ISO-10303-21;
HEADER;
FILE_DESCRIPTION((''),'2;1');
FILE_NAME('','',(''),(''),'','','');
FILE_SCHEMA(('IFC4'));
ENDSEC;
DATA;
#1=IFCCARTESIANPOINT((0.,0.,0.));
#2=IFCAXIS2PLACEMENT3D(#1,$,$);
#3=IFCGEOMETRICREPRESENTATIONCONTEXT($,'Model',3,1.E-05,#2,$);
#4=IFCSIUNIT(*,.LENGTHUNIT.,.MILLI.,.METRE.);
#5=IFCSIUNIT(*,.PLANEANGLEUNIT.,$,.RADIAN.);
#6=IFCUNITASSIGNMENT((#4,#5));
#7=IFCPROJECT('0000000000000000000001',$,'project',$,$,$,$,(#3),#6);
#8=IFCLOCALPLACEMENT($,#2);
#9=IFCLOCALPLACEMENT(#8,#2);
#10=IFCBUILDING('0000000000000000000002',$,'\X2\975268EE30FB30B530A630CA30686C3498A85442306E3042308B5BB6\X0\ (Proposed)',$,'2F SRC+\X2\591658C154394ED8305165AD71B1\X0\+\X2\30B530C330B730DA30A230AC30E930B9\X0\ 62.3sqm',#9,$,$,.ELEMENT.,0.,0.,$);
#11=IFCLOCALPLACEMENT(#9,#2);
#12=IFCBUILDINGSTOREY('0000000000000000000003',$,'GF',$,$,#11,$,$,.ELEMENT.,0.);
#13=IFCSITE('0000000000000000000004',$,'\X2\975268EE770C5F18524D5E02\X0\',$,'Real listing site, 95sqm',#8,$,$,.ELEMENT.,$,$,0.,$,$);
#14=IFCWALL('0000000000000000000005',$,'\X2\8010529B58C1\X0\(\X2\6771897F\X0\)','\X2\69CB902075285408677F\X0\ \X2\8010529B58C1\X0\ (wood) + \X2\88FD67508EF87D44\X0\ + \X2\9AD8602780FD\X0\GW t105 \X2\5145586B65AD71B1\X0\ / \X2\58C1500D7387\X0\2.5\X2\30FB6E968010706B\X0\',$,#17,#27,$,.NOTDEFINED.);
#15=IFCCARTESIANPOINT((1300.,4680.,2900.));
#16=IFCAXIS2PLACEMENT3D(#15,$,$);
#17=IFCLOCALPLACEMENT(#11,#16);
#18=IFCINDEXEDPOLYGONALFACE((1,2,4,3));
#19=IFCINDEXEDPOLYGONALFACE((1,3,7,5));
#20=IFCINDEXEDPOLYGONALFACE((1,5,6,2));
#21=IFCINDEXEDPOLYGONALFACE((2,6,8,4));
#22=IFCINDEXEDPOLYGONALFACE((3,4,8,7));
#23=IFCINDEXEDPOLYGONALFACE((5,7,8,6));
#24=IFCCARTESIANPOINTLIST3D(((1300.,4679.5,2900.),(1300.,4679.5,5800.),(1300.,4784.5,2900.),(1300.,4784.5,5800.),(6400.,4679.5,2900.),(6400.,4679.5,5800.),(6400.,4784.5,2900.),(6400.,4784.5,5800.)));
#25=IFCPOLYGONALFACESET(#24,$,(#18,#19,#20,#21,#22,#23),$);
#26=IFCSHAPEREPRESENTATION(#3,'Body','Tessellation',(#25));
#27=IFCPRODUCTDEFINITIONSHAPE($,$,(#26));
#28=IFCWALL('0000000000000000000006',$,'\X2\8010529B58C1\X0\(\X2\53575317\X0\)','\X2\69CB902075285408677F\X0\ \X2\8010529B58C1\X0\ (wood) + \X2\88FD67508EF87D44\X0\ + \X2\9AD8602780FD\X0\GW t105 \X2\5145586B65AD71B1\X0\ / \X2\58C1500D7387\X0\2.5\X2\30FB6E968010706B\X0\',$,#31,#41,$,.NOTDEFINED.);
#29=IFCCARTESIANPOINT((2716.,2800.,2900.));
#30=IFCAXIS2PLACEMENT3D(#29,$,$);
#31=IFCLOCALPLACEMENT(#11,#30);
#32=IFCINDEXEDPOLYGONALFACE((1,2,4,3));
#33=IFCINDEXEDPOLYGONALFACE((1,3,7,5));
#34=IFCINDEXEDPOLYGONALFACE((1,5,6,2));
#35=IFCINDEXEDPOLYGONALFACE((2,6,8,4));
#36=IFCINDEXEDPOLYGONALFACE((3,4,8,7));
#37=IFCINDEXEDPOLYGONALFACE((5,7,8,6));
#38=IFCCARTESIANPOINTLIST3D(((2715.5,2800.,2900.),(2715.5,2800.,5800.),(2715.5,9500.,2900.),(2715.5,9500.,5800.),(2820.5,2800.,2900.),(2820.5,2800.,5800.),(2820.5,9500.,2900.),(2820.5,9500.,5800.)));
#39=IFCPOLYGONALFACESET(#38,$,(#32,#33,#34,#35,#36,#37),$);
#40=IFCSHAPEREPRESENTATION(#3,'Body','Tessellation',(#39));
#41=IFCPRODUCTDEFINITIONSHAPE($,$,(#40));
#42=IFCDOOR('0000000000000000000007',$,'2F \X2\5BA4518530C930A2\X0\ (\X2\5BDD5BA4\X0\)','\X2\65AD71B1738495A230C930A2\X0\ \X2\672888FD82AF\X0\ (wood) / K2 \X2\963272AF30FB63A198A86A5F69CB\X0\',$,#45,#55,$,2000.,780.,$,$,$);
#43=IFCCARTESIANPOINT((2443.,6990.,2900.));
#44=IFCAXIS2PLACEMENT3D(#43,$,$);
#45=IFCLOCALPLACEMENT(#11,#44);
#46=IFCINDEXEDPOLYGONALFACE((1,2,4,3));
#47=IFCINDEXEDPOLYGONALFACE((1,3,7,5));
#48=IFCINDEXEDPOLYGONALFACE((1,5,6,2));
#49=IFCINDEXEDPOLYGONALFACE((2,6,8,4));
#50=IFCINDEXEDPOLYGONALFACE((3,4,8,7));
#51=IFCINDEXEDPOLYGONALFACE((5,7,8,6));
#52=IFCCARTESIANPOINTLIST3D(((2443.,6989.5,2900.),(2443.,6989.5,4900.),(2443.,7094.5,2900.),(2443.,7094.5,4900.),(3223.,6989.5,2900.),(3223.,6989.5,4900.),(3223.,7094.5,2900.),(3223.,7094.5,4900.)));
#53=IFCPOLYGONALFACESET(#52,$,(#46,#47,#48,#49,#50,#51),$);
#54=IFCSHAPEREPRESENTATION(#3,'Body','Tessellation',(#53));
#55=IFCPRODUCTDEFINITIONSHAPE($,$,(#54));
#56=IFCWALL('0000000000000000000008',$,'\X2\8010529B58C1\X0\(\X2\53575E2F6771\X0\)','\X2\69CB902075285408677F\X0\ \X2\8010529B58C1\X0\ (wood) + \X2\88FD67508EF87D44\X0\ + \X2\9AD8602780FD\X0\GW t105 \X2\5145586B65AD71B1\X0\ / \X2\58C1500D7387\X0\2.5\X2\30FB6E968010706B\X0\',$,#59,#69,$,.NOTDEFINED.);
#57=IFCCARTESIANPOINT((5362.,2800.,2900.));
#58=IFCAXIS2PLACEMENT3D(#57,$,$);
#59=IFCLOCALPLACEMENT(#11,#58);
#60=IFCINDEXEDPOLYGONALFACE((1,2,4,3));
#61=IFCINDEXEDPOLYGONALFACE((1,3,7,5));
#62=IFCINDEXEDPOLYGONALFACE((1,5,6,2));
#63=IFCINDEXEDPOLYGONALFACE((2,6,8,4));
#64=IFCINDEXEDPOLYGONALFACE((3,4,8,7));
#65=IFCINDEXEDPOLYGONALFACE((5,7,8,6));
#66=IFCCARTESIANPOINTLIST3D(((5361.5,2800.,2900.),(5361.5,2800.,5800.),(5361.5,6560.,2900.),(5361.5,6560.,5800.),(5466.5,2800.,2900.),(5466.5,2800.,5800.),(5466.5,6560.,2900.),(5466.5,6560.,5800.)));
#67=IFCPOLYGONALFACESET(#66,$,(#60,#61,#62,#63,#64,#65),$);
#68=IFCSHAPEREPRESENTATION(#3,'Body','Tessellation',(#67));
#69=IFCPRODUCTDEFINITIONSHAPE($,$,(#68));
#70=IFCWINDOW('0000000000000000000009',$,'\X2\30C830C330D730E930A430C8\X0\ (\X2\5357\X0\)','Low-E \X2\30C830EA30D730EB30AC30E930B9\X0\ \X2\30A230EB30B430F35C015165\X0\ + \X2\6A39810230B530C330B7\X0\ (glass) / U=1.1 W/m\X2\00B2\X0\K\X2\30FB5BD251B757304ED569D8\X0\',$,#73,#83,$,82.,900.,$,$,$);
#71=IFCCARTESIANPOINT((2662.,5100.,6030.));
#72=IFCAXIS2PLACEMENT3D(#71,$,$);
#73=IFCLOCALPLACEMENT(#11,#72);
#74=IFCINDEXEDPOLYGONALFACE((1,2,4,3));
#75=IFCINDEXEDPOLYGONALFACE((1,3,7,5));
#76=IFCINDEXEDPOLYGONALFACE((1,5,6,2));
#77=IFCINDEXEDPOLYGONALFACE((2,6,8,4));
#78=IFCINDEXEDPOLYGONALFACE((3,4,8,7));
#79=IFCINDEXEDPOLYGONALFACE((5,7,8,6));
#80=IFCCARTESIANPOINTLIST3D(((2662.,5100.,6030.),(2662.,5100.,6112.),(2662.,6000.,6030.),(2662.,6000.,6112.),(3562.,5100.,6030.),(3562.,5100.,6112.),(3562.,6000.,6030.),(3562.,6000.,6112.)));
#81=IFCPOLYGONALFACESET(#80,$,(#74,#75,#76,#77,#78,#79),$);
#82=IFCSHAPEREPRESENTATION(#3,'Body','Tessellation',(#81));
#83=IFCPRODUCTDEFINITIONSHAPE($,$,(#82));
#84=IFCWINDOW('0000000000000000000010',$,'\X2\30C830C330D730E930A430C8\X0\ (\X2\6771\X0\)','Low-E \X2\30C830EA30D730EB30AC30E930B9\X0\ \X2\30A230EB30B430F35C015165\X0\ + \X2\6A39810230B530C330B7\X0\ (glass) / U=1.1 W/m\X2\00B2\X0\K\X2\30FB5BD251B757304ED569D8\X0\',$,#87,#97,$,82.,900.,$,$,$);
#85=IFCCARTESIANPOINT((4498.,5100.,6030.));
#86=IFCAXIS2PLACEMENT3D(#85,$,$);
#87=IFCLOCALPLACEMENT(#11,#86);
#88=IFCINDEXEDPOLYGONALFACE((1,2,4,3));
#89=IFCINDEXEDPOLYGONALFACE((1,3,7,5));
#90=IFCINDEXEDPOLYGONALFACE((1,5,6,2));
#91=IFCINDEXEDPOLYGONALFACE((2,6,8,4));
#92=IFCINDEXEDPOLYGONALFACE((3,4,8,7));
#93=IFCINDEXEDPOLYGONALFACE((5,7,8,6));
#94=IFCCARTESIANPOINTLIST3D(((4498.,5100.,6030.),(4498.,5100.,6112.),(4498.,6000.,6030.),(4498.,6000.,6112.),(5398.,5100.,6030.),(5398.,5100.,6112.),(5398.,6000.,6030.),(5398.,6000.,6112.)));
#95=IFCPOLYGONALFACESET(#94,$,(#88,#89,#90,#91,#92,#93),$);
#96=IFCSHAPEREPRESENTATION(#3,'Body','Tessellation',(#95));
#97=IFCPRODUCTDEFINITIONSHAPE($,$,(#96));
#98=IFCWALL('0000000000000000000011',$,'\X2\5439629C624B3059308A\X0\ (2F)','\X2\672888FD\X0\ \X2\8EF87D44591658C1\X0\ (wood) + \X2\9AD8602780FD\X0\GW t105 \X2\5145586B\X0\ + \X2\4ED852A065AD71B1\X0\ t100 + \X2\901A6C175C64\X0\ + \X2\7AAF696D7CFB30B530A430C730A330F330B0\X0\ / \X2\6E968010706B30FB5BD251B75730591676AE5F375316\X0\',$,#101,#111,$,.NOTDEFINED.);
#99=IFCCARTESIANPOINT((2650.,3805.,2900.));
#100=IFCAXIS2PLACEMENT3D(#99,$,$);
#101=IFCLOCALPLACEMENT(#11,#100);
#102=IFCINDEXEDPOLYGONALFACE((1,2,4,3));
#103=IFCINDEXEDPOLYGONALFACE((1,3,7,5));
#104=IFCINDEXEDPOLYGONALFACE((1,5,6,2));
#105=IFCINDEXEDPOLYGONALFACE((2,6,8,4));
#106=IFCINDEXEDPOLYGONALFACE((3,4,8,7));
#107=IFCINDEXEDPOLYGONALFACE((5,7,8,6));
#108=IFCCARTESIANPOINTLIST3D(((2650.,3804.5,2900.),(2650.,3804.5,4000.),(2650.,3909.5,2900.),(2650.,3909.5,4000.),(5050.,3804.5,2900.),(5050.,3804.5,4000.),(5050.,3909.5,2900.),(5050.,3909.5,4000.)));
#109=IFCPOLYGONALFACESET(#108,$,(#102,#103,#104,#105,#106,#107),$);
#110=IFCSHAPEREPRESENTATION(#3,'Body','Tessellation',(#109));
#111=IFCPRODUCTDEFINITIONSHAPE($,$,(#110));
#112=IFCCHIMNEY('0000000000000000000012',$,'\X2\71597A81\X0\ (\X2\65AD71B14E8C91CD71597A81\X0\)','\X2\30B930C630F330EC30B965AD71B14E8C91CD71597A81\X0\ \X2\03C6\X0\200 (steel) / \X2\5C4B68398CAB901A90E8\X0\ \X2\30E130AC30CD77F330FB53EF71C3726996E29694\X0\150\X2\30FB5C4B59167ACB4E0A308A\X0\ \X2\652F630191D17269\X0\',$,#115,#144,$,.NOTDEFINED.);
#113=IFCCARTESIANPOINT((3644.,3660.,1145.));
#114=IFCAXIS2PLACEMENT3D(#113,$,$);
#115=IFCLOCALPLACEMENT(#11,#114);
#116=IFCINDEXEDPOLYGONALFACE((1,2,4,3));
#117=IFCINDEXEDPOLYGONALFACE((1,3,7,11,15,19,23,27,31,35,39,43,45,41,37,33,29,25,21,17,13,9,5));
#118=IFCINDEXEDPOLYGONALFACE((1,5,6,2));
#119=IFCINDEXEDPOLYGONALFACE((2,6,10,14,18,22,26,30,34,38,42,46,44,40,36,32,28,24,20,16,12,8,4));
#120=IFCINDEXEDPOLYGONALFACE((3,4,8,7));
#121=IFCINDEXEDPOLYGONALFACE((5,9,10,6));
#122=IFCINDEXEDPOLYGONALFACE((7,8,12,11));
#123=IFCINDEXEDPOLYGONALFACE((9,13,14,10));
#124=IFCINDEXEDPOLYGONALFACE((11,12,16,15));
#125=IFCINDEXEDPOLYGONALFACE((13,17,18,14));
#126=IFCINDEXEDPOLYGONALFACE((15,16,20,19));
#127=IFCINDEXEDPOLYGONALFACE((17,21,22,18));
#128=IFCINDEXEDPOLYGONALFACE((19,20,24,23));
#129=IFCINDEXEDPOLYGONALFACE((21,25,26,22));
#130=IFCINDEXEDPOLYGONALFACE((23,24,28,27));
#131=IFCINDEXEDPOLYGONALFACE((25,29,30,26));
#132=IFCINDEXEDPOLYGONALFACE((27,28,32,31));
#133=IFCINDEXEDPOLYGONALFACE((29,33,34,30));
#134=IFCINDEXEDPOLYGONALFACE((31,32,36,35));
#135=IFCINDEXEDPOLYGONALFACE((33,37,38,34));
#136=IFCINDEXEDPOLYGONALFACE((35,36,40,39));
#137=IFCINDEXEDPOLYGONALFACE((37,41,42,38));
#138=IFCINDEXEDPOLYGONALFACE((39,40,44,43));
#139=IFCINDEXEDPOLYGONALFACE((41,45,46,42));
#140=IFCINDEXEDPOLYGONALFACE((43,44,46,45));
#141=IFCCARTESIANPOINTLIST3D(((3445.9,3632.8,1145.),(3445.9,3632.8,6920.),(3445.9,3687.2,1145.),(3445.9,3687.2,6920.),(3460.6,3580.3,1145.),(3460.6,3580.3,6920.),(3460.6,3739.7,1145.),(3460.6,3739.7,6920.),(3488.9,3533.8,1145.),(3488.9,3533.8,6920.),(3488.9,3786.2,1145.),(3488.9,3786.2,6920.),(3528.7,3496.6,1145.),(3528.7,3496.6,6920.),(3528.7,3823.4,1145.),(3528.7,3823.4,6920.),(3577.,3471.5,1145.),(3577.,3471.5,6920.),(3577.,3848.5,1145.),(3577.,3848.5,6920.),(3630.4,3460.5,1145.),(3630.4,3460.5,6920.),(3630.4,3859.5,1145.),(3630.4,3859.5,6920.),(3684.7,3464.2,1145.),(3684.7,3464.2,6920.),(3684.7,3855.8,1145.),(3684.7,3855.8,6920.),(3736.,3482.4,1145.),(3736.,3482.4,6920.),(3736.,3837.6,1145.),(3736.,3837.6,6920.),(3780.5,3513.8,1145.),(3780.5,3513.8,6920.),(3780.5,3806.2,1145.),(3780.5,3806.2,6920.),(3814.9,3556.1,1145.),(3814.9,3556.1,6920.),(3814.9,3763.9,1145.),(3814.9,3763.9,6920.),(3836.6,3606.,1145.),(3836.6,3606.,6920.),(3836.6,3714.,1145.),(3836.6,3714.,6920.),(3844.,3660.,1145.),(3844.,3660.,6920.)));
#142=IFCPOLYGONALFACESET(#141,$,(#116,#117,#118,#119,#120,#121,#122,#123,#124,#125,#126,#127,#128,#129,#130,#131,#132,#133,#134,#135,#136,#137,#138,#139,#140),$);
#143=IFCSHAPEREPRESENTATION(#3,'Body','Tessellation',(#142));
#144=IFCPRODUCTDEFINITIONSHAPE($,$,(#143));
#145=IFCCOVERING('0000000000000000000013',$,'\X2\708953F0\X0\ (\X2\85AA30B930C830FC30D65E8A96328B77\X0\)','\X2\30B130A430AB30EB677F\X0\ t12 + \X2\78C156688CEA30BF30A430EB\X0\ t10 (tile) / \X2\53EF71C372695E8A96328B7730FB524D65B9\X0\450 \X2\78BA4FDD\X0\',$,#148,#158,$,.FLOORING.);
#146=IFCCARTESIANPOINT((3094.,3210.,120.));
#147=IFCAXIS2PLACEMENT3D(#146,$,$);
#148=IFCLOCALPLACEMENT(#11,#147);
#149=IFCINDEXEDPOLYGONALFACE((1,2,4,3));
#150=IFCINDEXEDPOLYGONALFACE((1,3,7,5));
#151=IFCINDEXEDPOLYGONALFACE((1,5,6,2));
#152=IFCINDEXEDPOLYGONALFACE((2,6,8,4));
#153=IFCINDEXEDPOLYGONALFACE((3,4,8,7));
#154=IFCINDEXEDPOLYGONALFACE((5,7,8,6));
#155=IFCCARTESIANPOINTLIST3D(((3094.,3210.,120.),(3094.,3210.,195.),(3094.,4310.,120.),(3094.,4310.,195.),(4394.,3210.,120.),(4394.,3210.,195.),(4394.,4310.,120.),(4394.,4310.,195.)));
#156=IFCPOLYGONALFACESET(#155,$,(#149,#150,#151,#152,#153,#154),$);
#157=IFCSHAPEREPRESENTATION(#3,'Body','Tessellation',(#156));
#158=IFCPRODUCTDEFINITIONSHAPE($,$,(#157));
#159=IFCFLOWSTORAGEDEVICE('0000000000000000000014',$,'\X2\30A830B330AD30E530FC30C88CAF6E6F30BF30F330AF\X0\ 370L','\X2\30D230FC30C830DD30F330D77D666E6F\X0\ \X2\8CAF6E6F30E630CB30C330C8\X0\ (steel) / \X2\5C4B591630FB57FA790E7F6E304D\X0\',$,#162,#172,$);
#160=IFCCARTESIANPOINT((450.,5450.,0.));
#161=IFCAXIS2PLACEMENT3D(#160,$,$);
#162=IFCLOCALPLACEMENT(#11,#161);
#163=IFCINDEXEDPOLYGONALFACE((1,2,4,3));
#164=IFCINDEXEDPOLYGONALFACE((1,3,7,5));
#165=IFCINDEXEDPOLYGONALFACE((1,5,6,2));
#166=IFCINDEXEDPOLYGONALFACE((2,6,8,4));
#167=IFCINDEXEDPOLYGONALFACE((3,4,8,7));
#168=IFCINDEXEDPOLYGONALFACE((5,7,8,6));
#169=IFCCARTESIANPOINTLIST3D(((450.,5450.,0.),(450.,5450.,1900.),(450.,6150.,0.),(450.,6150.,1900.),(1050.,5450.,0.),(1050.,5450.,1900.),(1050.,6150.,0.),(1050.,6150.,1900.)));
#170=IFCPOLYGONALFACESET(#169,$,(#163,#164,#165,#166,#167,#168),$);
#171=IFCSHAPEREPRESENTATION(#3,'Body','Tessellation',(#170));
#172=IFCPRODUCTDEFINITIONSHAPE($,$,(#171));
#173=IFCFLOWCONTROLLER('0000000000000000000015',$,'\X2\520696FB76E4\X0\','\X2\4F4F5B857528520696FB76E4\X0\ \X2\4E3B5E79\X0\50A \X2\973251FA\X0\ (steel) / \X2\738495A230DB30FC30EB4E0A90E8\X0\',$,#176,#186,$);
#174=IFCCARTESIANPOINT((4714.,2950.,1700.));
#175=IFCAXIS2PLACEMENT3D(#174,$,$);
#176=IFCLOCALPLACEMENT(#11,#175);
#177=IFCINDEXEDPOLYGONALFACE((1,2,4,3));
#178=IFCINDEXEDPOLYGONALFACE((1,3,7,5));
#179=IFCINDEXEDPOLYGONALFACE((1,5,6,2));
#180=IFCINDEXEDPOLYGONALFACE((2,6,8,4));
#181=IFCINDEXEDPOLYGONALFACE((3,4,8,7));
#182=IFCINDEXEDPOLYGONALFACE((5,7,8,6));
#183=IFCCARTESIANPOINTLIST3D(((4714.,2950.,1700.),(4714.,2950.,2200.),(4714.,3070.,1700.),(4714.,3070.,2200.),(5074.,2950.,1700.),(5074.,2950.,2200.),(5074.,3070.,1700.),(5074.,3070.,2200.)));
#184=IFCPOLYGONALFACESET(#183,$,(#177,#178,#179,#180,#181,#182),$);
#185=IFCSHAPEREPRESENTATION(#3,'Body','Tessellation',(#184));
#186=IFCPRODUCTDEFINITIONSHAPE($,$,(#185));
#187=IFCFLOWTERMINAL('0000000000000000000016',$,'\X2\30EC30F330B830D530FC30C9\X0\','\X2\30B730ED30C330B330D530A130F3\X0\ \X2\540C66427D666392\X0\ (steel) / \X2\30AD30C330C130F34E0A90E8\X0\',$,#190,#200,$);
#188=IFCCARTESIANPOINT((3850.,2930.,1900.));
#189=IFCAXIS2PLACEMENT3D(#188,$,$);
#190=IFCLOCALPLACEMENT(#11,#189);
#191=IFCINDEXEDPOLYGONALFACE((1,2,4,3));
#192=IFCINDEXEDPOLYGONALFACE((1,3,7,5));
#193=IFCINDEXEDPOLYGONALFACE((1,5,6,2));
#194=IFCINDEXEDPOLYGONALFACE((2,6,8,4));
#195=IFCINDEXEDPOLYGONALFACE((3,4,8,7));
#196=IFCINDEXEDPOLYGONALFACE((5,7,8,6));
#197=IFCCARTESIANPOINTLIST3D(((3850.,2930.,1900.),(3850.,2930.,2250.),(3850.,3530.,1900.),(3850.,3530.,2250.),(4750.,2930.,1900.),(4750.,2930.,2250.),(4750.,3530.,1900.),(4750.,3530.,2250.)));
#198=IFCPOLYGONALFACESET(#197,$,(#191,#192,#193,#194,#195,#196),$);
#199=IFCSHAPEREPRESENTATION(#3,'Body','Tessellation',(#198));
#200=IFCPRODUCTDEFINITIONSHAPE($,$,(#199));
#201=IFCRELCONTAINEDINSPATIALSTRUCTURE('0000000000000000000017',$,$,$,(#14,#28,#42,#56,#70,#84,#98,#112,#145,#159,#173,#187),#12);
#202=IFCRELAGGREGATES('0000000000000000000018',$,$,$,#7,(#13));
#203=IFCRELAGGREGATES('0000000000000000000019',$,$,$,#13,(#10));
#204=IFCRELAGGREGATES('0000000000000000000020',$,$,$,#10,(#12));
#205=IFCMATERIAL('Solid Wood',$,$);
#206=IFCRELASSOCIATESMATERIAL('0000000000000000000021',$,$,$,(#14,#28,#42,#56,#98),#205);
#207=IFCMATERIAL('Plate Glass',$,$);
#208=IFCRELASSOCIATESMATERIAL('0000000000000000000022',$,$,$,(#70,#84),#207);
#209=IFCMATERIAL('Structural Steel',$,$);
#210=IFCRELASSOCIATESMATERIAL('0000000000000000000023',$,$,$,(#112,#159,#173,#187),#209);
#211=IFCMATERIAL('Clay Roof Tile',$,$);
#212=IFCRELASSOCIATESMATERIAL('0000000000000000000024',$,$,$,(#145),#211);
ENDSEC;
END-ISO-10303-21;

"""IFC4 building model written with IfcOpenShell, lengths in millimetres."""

from ifc_helpers import new_model, si_unit, frame, frame_2d, origin, origin_2d, place, context, project, spatial, rectangle, circle, extrude, material, element, fill, save


model = new_model("IFC4")

# Units and contexts
model_context = context("Model", 3, precision=1e-05, world=origin())
ifc_project = project(units=[si_unit("LENGTHUNIT", "METRE", prefix="MILLI"), si_unit("PLANEANGLEUNIT", "RADIAN")], contexts=[model_context])

# Site, building, storey
site_placement = place(None, origin())
site = spatial("IfcSite", under=ifc_project, at=site_placement, Name="青森県弘前市", ObjectType="Real listing site, 95sqm", CompositionType="ELEMENT", RefElevation=0.0)
building_placement = place(site_placement, origin())
building = spatial("IfcBuilding", under=site, at=building_placement, Name="青森・サウナと水風呂のある家 (Proposed)", ObjectType="2F SRC+外壁吹付け断熱+サッシペアガラス 62.3sqm", CompositionType="ELEMENT", ElevationOfRefHeight=0.0, ElevationOfTerrain=0.0)
storey_placement = place(building_placement, origin())
storey = spatial("IfcBuildingStorey", under=building, at=storey_placement, Name="GF", CompositionType="ELEMENT", Elevation=0.0)

# Shared definitions
ifc_material_1 = material(Name="Solid Wood")

# Wall
wall_1_placement = place(storey_placement, frame((1300.0, 4680.0, 2900.0)))
element("IfcWall", 1, at=wall_1_placement, inside=storey, material=ifc_material_1, Name="耐力壁(東西)", Description="構造用合板 耐力壁 (wood) + 製材軸組 + 高性能GW t105 充填断熱 / 壁倍率2.5・準耐火", PredefinedType="NOTDEFINED", context=model_context, shape_type="SweptSolid", body=[
    extrude(rectangle(XDim=5100.0, YDim=105.0, at=frame_2d((2550.0, 52.0))), frame((1300.0, 4680.0, 2900.0)), (0.0, 0.0, 1.0), 2900.0),
])

# Wall, opening, door
wall_2_placement = place(storey_placement, frame((2716.0, 2800.0, 2900.0)))
wall_2 = element("IfcWall", 2, at=wall_2_placement, inside=storey, material=ifc_material_1, Name="耐力壁(南北)", Description="構造用合板 耐力壁 (wood) + 製材軸組 + 高性能GW t105 充填断熱 / 壁倍率2.5・準耐火", PredefinedType="NOTDEFINED", context=model_context, shape_type="SweptSolid", body=[
    extrude(rectangle(XDim=105.0, YDim=6700.0, at=frame_2d((52.0, 3350.0))), frame((2716.0, 2800.0, 2900.0)), (0.0, 0.0, 1.0), 2900.0),
])
opening_placement = place(storey_placement, frame((2443.0, 6990.0, 2900.0)))
opening = element("IfcOpeningElement", 3, at=opening_placement, cuts=wall_2, PredefinedType="NOTDEFINED", context=model_context, shape_type="SweptSolid", body=[
    extrude(rectangle(XDim=780.0, YDim=105.0, at=frame_2d((390.0, 52.0))), frame((2443.0, 6990.0, 2900.0)), (0.0, 0.0, 1.0), 2000.0),
])
door_placement = place(storey_placement, frame((2443.0, 6990.0, 2900.0)))
door = element("IfcDoor", 4, at=door_placement, inside=storey, material=ifc_material_1, Name="2F 室内ドア (寝室)", Description="断熱玄関ドア 木製芯 (wood) / K2 防犯・採風機構", OverallHeight=2000.0, OverallWidth=780.0, context=model_context, shape_type="SweptSolid", body=[
    extrude(rectangle(XDim=780.0, YDim=105.0, at=frame_2d((390.0, 52.0))), frame((2443.0, 6990.0, 2900.0)), (0.0, 0.0, 1.0), 2000.0),
])
fill(opening, door)

# Wall
wall_3_placement = place(storey_placement, frame((5362.0, 2800.0, 2900.0)))
element("IfcWall", 5, at=wall_3_placement, inside=storey, material=ifc_material_1, Name="耐力壁(南帯東)", Description="構造用合板 耐力壁 (wood) + 製材軸組 + 高性能GW t105 充填断熱 / 壁倍率2.5・準耐火", PredefinedType="NOTDEFINED", context=model_context, shape_type="SweptSolid", body=[
    extrude(rectangle(XDim=105.0, YDim=3760.0, at=frame_2d((52.0, 1880.0))), frame((5362.0, 2800.0, 2900.0)), (0.0, 0.0, 1.0), 2900.0),
])

# Windows
ifc_material_2 = material(Name="Plate Glass")
window_1_placement = place(storey_placement, frame((2662.0, 5100.0, 6030.0)))
element("IfcWindow", 6, at=window_1_placement, inside=storey, material=ifc_material_2, Name="トップライト (南)", Description="Low-E トリプルガラス アルゴン封入 + 樹脂サッシ (glass) / U=1.1 W/m²K・寒冷地仕様", OverallHeight=82.0, OverallWidth=900.0, context=model_context, shape_type="SweptSolid", body=[
    extrude(rectangle(XDim=900.0, YDim=900.0, at=frame_2d((450.0, 450.0))), frame((2662.0, 5100.0, 6030.0)), (0.0, 0.0, 1.0), 82.0),
])
window_2_placement = place(storey_placement, frame((4498.0, 5100.0, 6030.0)))
element("IfcWindow", 7, at=window_2_placement, inside=storey, material=ifc_material_2, Name="トップライト (東)", Description="Low-E トリプルガラス アルゴン封入 + 樹脂サッシ (glass) / U=1.1 W/m²K・寒冷地仕様", OverallHeight=82.0, OverallWidth=900.0, context=model_context, shape_type="SweptSolid", body=[
    extrude(rectangle(XDim=900.0, YDim=900.0, at=frame_2d((450.0, 450.0))), frame((4498.0, 5100.0, 6030.0)), (0.0, 0.0, 1.0), 82.0),
])

# Wall
wall_4_placement = place(storey_placement, frame((2650.0, 3805.0, 2900.0)))
element("IfcWall", 8, at=wall_4_placement, inside=storey, material=ifc_material_1, Name="吹抜手すり (2F)", Description="木製 軸組外壁 (wood) + 高性能GW t105 充填 + 付加断熱 t100 + 通気層 + 窯業系サイディング / 準耐火・寒冷地外皮強化", PredefinedType="NOTDEFINED", context=model_context, shape_type="SweptSolid", body=[
    extrude(rectangle(XDim=2400.0, YDim=105.0, at=frame_2d((1200.0, 52.0))), frame((2650.0, 3805.0, 2900.0)), (0.0, 0.0, 1.0), 1100.0),
])

# Chimney
ifc_material_3 = material(Name="Structural Steel")
chimney_placement = place(storey_placement, frame((3644.0, 3660.0, 1145.0)))
element("IfcChimney", 9, at=chimney_placement, inside=storey, material=ifc_material_3, Name="煙突 (断熱二重煙突)", Description="ステンレス断熱二重煙突 φ200 (steel) / 屋根貫通部 メガネ石・可燃物離隔150・屋外立上り 支持金物", PredefinedType="NOTDEFINED", context=model_context, shape_type="SweptSolid", body=[
    extrude(circle(Radius=200.0, at=origin_2d()), frame((3644.0, 3660.0, 1145.0)), (0.0, 0.0, 1.0), 5775.0),
])

# Covering
ifc_material_4 = material(Name="Clay Roof Tile")
covering_placement = place(storey_placement, frame((3094.0, 3210.0, 120.0)))
element("IfcCovering", 10, at=covering_placement, inside=storey, material=ifc_material_4, Name="炉台 (薪ストーブ床防護)", Description="ケイカル板 t12 + 磁器質タイル t10 (tile) / 可燃物床防護・前方450 確保", PredefinedType="FLOORING", context=model_context, shape_type="SweptSolid", body=[
    extrude(rectangle(XDim=1300.0, YDim=1100.0, at=frame_2d((650.0, 550.0))), frame((3094.0, 3210.0, 120.0)), (0.0, 0.0, 1.0), 75.0),
])

# Flow storage device
flow_storage_device_placement = place(storey_placement, frame((450.0, 5450.0, 0.0)))
element("IfcFlowStorageDevice", 11, at=flow_storage_device_placement, inside=storey, material=ifc_material_3, Name="エコキュート貯湯タンク 370L", Description="ヒートポンプ給湯 貯湯ユニット (steel) / 屋外・基礎置き", context=model_context, shape_type="SweptSolid", body=[
    extrude(rectangle(XDim=600.0, YDim=700.0, at=frame_2d((300.0, 350.0))), frame((450.0, 5450.0, 0.0)), (0.0, 0.0, 1.0), 1900.0),
])

# Flow controller
flow_controller_placement = place(storey_placement, frame((4714.0, 2950.0, 1700.0)))
element("IfcFlowController", 12, at=flow_controller_placement, inside=storey, material=ifc_material_3, Name="分電盤", Description="住宅用分電盤 主幹50A 露出 (steel) / 玄関ホール上部", context=model_context, shape_type="SweptSolid", body=[
    extrude(rectangle(XDim=360.0, YDim=120.0, at=frame_2d((180.0, 60.0))), frame((4714.0, 2950.0, 1700.0)), (0.0, 0.0, 1.0), 500.0),
])

# Flow terminal
flow_terminal_1_placement = place(storey_placement, frame((3850.0, 2930.0, 1900.0)))
element("IfcFlowTerminal", 13, at=flow_terminal_1_placement, inside=storey, material=ifc_material_3, Name="レンジフード", Description="シロッコファン 同時給排 (steel) / キッチン上部", context=model_context, shape_type="SweptSolid", body=[
    extrude(rectangle(XDim=900.0, YDim=600.0, at=frame_2d((450.0, 300.0))), frame((3850.0, 2930.0, 1900.0)), (0.0, 0.0, 1.0), 350.0),
])

save(model, "model.ifc")
